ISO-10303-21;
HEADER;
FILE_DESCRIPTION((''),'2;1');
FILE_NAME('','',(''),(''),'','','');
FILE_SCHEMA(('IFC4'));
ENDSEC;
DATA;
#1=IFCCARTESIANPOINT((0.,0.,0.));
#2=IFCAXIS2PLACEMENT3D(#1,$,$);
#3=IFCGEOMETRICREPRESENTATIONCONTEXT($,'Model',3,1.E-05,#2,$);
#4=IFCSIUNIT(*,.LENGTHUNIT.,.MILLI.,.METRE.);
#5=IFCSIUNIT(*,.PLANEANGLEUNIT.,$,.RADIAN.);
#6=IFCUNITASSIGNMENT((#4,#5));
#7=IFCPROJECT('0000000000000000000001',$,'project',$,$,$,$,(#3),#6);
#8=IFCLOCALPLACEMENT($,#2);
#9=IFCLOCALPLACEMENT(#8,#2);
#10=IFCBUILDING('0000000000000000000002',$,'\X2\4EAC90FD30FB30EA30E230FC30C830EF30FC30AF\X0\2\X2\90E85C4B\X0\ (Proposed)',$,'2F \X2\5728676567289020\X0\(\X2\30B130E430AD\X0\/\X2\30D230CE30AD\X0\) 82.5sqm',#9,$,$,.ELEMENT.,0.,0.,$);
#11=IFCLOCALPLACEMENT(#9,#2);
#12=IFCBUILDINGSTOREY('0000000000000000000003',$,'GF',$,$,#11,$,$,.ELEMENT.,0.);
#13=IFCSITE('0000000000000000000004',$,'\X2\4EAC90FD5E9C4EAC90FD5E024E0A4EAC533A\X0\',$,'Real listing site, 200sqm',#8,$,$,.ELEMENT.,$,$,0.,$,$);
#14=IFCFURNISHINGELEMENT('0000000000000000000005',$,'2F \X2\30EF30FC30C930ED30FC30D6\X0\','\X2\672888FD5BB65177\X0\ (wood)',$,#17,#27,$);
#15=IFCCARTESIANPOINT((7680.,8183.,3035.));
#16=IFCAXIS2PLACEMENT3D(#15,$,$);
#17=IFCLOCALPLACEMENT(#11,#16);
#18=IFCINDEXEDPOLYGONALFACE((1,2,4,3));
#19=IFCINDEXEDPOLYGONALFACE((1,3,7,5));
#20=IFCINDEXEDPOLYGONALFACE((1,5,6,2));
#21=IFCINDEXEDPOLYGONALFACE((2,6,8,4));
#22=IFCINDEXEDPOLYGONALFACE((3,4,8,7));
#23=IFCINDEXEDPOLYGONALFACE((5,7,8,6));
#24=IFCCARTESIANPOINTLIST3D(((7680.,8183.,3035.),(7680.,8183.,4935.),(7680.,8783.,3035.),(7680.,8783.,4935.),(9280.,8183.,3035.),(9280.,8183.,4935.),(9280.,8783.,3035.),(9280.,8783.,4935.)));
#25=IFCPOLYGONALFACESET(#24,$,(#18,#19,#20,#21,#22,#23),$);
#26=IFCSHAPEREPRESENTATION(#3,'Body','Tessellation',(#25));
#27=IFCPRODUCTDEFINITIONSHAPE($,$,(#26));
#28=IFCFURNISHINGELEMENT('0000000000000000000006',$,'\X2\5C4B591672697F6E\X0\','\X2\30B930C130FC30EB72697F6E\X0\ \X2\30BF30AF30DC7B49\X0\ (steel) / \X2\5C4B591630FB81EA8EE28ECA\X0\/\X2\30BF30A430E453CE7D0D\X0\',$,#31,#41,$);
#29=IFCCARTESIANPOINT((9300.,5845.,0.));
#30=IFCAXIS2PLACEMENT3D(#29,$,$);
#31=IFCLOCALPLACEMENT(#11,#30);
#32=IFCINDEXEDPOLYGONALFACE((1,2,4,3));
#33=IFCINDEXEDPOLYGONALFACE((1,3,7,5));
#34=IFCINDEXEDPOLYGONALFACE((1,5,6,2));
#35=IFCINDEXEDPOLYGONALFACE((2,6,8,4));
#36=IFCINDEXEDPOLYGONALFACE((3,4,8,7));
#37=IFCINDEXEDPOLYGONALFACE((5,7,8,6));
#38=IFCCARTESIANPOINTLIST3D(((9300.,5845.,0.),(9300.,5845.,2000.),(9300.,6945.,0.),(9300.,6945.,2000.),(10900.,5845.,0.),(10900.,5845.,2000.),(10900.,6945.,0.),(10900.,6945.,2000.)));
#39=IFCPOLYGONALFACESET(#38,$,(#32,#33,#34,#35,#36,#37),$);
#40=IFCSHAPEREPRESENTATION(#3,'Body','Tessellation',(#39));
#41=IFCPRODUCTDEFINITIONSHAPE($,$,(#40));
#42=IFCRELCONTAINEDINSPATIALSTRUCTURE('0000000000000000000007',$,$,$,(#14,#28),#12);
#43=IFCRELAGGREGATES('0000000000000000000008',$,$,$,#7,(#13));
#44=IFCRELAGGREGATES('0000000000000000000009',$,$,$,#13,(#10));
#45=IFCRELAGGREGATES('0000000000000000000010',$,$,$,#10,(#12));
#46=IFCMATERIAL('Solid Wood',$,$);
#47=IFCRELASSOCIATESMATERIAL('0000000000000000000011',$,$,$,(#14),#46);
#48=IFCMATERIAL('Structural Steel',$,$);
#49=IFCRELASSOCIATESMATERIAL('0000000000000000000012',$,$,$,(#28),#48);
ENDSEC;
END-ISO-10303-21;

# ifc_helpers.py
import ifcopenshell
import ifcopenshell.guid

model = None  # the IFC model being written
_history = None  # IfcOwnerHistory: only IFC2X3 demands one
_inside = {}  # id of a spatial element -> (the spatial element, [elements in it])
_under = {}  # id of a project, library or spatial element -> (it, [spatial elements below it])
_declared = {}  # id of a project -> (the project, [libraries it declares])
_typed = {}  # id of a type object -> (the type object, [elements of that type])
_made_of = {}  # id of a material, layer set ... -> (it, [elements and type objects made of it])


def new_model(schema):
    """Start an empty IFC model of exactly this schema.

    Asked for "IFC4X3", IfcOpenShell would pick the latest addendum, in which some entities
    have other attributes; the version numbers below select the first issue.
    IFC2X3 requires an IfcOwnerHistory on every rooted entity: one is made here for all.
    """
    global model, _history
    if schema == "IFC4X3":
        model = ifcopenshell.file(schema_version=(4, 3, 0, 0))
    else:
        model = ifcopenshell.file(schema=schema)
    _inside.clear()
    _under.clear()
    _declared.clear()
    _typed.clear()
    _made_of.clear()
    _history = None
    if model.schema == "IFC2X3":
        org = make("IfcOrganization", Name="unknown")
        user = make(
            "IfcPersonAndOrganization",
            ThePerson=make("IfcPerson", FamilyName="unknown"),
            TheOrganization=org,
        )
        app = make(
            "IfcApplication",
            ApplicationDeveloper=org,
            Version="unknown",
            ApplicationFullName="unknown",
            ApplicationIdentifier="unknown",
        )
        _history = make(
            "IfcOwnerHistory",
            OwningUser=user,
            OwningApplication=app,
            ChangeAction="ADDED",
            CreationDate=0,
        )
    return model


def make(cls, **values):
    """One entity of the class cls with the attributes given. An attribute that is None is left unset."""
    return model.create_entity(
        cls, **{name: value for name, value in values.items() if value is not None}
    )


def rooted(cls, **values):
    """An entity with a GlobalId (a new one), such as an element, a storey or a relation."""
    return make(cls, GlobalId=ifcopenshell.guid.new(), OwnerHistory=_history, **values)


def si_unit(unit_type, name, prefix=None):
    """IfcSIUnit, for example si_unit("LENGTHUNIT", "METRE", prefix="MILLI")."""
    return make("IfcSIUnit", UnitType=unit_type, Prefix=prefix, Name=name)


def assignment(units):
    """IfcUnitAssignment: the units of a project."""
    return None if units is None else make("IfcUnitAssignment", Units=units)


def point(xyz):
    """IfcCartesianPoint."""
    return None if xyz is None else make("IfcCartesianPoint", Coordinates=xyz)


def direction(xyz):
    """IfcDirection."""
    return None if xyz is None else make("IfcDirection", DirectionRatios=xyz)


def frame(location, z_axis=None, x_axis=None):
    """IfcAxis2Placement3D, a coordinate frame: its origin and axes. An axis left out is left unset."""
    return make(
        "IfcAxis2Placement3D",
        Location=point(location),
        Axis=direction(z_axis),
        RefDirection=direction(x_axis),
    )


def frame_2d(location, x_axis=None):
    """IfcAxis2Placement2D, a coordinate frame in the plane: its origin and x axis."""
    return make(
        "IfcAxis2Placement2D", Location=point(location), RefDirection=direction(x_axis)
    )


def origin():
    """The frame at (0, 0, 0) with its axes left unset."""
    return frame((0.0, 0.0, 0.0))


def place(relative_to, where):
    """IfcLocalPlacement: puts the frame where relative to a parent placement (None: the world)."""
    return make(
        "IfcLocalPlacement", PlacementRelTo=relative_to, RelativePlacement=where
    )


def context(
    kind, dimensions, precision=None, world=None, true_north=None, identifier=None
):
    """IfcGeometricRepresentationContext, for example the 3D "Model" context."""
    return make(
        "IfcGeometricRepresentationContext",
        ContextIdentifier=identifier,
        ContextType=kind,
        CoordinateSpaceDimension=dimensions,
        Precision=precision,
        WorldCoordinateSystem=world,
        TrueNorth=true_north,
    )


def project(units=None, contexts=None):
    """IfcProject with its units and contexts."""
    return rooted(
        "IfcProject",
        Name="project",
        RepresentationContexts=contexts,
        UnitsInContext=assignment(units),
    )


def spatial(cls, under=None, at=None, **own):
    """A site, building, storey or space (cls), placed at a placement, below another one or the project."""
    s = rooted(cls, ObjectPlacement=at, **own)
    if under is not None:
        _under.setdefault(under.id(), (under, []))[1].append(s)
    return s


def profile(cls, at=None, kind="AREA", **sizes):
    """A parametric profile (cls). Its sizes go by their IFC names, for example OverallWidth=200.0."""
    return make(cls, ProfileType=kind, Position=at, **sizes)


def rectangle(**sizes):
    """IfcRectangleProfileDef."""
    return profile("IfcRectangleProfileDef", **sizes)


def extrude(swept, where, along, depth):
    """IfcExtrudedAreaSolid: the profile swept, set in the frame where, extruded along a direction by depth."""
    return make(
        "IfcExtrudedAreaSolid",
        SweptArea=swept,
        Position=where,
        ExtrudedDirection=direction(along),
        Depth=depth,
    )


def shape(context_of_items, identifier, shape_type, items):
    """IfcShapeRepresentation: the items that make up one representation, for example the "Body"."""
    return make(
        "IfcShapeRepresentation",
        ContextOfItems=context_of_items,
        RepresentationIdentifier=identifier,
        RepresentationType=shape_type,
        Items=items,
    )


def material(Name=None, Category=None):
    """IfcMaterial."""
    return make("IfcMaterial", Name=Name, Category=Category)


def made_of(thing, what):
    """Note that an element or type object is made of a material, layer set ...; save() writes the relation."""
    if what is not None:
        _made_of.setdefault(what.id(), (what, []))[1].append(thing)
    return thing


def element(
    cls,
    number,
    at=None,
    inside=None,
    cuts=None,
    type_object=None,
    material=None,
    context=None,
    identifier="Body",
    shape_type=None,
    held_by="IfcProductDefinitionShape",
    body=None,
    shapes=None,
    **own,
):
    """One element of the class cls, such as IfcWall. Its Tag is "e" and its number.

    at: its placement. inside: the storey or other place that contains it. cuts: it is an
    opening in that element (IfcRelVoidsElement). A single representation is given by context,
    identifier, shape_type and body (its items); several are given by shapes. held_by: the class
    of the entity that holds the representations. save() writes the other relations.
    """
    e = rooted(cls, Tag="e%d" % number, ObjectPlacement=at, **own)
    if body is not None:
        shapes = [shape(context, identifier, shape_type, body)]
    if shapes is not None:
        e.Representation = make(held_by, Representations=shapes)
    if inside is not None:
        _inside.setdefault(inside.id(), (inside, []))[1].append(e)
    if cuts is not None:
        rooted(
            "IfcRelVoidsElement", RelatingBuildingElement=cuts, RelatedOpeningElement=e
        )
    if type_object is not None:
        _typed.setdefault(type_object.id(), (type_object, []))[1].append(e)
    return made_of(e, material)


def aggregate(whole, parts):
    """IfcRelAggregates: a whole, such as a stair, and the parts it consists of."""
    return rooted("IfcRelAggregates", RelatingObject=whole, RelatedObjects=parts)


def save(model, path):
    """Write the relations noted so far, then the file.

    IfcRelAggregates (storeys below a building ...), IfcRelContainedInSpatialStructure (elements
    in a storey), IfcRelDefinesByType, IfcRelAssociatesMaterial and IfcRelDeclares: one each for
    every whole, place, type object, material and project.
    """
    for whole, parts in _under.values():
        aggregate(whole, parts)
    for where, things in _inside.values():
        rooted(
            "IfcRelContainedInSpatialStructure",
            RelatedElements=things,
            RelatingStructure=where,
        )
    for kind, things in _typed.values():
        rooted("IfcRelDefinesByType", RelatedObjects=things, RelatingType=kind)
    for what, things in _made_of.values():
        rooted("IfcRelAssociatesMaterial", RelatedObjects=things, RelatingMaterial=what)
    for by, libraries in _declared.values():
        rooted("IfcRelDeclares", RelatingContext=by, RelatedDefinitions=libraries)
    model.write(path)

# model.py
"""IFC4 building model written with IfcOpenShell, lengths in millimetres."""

from ifc_helpers import new_model, si_unit, frame, frame_2d, origin, place, context, project, spatial, rectangle, extrude, material, element, save


model = new_model("IFC4")

# Units and contexts
model_context = context("Model", 3, precision=1e-05, world=origin())
ifc_project = project(units=[si_unit("LENGTHUNIT", "METRE", prefix="MILLI"), si_unit("PLANEANGLEUNIT", "RADIAN")], contexts=[model_context])

# Site, building, storey
site_placement = place(None, origin())
site = spatial("IfcSite", under=ifc_project, at=site_placement, Name="京都府京都市上京区", ObjectType="Real listing site, 200sqm", CompositionType="ELEMENT", RefElevation=0.0)
building_placement = place(site_placement, origin())
building = spatial("IfcBuilding", under=site, at=building_placement, Name="京都・リモートワーク2部屋 (Proposed)", ObjectType="2F 在来木造(ケヤキ/ヒノキ) 82.5sqm", CompositionType="ELEMENT", ElevationOfRefHeight=0.0, ElevationOfTerrain=0.0)
storey_placement = place(building_placement, origin())
storey = spatial("IfcBuildingStorey", under=building, at=storey_placement, Name="GF", CompositionType="ELEMENT", Elevation=0.0)

# Shared definitions
ifc_material_1 = material(Name="Solid Wood")

# Shared definitions
ifc_material_2 = material(Name="Structural Steel")

# Furnishing elements
furnishing_1_placement = place(storey_placement, frame((7680.0, 8183.0, 3035.0)))
element("IfcFurnishingElement", 1, at=furnishing_1_placement, inside=storey, material=ifc_material_1, Name="2F ワードローブ", Description="木製家具 (wood)", context=model_context, shape_type="SweptSolid", body=[
    extrude(rectangle(XDim=1600.0, YDim=600.0, at=frame_2d((800.0, 300.0))), frame((7680.0, 8183.0, 3035.0)), (0.0, 0.0, 1.0), 1900.0),
])
furnishing_2_placement = place(storey_placement, frame((9300.0, 5845.0, 0.0)))
element("IfcFurnishingElement", 2, at=furnishing_2_placement, inside=storey, material=ifc_material_2, Name="屋外物置", Description="スチール物置 タクボ等 (steel) / 屋外・自転車/タイヤ収納", context=model_context, shape_type="SweptSolid", body=[
    extrude(rectangle(XDim=1600.0, YDim=1100.0, at=frame_2d((800.0, 550.0))), frame((9300.0, 5845.0, 0.0)), (0.0, 0.0, 1.0), 2000.0),
])

save(model, "model.ifc")
